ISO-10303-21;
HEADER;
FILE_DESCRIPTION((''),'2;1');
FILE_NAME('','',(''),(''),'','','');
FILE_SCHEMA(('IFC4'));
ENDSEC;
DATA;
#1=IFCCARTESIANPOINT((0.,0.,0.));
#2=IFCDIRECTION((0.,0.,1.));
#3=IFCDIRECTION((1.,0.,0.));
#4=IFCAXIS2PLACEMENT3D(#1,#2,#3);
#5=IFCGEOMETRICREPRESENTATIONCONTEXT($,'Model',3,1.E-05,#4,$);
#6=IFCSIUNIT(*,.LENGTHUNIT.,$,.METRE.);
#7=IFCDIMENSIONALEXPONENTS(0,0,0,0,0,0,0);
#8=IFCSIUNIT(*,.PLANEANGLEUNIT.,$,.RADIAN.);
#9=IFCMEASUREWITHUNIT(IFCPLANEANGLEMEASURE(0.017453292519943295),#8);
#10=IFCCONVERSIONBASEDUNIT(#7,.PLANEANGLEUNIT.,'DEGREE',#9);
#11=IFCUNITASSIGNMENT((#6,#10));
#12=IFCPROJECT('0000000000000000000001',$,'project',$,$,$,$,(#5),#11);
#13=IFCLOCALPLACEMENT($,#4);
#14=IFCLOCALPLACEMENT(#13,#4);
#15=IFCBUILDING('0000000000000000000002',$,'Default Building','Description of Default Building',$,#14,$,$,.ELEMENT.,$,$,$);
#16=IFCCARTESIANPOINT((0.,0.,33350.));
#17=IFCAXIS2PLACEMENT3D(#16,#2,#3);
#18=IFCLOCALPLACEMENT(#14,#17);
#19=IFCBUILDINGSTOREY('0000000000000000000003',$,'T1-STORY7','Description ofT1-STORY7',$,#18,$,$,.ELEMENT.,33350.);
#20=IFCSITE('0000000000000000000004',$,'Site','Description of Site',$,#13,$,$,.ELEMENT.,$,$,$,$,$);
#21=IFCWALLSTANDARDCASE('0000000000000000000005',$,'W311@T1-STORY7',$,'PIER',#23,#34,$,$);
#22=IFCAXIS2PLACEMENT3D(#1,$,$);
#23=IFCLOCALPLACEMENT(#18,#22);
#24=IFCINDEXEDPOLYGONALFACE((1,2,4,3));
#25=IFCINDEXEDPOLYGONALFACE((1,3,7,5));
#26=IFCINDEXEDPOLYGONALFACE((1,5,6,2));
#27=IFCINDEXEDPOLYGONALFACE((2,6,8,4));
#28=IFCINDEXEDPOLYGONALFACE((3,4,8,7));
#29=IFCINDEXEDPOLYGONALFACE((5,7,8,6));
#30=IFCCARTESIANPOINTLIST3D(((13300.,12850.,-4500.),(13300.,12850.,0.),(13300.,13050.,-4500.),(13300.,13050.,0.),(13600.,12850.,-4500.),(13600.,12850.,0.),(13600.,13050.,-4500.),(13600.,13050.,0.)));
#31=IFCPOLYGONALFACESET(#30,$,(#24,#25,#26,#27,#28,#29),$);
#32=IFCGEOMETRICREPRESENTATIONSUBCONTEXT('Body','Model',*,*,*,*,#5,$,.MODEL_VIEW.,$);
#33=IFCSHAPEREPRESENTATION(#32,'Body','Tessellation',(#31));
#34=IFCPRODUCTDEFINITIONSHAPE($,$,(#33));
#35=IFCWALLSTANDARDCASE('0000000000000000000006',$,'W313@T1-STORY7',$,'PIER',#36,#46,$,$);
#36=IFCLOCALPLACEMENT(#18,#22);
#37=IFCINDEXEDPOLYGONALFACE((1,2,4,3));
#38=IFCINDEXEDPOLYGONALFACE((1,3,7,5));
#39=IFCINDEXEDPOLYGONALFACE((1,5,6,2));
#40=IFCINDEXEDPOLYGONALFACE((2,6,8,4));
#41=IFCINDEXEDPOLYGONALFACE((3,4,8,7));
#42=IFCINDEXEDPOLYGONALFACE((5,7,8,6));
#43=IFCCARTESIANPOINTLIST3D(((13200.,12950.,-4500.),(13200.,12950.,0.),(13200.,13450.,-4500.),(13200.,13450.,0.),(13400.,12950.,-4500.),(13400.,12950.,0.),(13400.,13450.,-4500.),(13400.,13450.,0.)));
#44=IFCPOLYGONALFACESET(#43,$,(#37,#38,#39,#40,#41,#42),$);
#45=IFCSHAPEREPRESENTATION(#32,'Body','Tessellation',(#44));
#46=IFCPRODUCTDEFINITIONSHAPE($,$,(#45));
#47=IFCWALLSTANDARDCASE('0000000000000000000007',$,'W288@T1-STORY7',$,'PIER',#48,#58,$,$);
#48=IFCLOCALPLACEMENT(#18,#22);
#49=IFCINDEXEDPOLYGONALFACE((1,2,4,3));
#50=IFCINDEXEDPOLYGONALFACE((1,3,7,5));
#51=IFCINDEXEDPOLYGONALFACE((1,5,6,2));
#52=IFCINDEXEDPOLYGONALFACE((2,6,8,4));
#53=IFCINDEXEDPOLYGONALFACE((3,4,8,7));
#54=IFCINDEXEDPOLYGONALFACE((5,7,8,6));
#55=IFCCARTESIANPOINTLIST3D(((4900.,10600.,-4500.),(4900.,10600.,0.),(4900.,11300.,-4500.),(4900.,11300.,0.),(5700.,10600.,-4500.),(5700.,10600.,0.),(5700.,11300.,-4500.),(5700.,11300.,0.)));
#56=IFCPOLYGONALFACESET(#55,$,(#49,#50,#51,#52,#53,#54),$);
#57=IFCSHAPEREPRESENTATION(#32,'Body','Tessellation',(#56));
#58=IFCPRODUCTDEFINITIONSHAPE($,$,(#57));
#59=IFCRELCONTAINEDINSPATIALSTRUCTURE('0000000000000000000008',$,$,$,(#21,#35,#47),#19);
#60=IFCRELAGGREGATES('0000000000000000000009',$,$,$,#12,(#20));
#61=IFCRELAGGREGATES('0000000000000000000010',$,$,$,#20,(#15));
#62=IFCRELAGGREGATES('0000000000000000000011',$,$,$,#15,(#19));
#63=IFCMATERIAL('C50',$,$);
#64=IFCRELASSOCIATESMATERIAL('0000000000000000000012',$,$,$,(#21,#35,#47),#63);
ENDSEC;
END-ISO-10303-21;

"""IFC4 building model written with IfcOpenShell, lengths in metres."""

from ifc_helpers import new_model, entity, si_unit, converted_unit, frame, origin_with_axes, place, context, subcontext, project, spatial, indexed_curve, outline, extrude, material, element, save


model = new_model("IFC4")

# Units and contexts
model_context = context("Model", 3, precision=1e-05, world=origin_with_axes())
body_context = subcontext(model_context, "Body", "Model", "MODEL_VIEW")
ifc_project = project(units=[si_unit("LENGTHUNIT", "METRE"), converted_unit("PLANEANGLEUNIT", "DEGREE", entity("IfcPlaneAngleMeasure", 0.017453292519943295), si_unit("PLANEANGLEUNIT", "RADIAN"), dimensions=[0, 0, 0, 0, 0, 0, 0])], contexts=[model_context])

# Site, building, storey
site_placement = place(None, origin_with_axes())
site = spatial("IfcSite", under=ifc_project, at=site_placement, Name="Site", Description="Description of Site", CompositionType="ELEMENT")
building_placement = place(site_placement, origin_with_axes())
building = spatial("IfcBuilding", under=site, at=building_placement, Name="Default Building", Description="Description of Default Building", CompositionType="ELEMENT")
storey_placement = place(building_placement, frame((0.0, 0.0, 33350.0), z_axis=(0.0, 0.0, 1.0), x_axis=(1.0, 0.0, 0.0)))
storey = spatial("IfcBuildingStorey", under=building, at=storey_placement, Name="T1-STORY7", Description="Description ofT1-STORY7", CompositionType="ELEMENT", Elevation=33350.0)

# Shared definitions
ifc_material_1 = material(Name="C50")

# Walls
wall_1_placement = place(storey_placement, frame((13300.0, 12950.0, -4500.0), z_axis=(0.0, 0.0, 1.0), x_axis=(1.0, 0.0, 0.0)))
element("IfcWallStandardCase", 1, at=wall_1_placement, inside=storey, material=ifc_material_1, Name="W311@T1-STORY7", ObjectType="PIER", context=body_context, shape_type="SweptSolid", body=[
    extrude(outline(indexed_curve([(0.0, -100.0), (0.0, 100.0), (300.0, 100.0), (300.0, -100.0), (0.0, -100.0)], self_intersect=False)), origin_with_axes(), (0.0, 0.0, 1.0), 4500.0),
])
wall_2_placement = place(storey_placement, frame((13300.0, 12950.0, -4500.0), z_axis=(0.0, 0.0, 1.0), x_axis=(0.0, 1.0, 0.0)))
element("IfcWallStandardCase", 2, at=wall_2_placement, inside=storey, material=ifc_material_1, Name="W313@T1-STORY7", ObjectType="PIER", context=body_context, shape_type="SweptSolid", body=[
    extrude(outline(indexed_curve([(0.0, -100.0), (0.0, 100.0), (500.0, 100.0), (500.0, -100.0), (0.0, -100.0)], self_intersect=False)), origin_with_axes(), (0.0, 0.0, 1.0), 4500.0),
])
wall_3_placement = place(storey_placement, frame((5300.0, 10600.0, -4500.0), z_axis=(0.0, 0.0, 1.0), x_axis=(0.0, 1.0, 0.0)))
element("IfcWallStandardCase", 3, at=wall_3_placement, inside=storey, material=ifc_material_1, Name="W288@T1-STORY7", ObjectType="PIER", context=body_context, shape_type="SweptSolid", body=[
    extrude(outline(indexed_curve([(0.0, -400.0), (0.0, 400.0), (700.0, 400.0), (700.0, -400.0), (0.0, -400.0)], self_intersect=False)), origin_with_axes(), (0.0, 0.0, 1.0), 4500.0),
])

save(model, "model.ifc")
